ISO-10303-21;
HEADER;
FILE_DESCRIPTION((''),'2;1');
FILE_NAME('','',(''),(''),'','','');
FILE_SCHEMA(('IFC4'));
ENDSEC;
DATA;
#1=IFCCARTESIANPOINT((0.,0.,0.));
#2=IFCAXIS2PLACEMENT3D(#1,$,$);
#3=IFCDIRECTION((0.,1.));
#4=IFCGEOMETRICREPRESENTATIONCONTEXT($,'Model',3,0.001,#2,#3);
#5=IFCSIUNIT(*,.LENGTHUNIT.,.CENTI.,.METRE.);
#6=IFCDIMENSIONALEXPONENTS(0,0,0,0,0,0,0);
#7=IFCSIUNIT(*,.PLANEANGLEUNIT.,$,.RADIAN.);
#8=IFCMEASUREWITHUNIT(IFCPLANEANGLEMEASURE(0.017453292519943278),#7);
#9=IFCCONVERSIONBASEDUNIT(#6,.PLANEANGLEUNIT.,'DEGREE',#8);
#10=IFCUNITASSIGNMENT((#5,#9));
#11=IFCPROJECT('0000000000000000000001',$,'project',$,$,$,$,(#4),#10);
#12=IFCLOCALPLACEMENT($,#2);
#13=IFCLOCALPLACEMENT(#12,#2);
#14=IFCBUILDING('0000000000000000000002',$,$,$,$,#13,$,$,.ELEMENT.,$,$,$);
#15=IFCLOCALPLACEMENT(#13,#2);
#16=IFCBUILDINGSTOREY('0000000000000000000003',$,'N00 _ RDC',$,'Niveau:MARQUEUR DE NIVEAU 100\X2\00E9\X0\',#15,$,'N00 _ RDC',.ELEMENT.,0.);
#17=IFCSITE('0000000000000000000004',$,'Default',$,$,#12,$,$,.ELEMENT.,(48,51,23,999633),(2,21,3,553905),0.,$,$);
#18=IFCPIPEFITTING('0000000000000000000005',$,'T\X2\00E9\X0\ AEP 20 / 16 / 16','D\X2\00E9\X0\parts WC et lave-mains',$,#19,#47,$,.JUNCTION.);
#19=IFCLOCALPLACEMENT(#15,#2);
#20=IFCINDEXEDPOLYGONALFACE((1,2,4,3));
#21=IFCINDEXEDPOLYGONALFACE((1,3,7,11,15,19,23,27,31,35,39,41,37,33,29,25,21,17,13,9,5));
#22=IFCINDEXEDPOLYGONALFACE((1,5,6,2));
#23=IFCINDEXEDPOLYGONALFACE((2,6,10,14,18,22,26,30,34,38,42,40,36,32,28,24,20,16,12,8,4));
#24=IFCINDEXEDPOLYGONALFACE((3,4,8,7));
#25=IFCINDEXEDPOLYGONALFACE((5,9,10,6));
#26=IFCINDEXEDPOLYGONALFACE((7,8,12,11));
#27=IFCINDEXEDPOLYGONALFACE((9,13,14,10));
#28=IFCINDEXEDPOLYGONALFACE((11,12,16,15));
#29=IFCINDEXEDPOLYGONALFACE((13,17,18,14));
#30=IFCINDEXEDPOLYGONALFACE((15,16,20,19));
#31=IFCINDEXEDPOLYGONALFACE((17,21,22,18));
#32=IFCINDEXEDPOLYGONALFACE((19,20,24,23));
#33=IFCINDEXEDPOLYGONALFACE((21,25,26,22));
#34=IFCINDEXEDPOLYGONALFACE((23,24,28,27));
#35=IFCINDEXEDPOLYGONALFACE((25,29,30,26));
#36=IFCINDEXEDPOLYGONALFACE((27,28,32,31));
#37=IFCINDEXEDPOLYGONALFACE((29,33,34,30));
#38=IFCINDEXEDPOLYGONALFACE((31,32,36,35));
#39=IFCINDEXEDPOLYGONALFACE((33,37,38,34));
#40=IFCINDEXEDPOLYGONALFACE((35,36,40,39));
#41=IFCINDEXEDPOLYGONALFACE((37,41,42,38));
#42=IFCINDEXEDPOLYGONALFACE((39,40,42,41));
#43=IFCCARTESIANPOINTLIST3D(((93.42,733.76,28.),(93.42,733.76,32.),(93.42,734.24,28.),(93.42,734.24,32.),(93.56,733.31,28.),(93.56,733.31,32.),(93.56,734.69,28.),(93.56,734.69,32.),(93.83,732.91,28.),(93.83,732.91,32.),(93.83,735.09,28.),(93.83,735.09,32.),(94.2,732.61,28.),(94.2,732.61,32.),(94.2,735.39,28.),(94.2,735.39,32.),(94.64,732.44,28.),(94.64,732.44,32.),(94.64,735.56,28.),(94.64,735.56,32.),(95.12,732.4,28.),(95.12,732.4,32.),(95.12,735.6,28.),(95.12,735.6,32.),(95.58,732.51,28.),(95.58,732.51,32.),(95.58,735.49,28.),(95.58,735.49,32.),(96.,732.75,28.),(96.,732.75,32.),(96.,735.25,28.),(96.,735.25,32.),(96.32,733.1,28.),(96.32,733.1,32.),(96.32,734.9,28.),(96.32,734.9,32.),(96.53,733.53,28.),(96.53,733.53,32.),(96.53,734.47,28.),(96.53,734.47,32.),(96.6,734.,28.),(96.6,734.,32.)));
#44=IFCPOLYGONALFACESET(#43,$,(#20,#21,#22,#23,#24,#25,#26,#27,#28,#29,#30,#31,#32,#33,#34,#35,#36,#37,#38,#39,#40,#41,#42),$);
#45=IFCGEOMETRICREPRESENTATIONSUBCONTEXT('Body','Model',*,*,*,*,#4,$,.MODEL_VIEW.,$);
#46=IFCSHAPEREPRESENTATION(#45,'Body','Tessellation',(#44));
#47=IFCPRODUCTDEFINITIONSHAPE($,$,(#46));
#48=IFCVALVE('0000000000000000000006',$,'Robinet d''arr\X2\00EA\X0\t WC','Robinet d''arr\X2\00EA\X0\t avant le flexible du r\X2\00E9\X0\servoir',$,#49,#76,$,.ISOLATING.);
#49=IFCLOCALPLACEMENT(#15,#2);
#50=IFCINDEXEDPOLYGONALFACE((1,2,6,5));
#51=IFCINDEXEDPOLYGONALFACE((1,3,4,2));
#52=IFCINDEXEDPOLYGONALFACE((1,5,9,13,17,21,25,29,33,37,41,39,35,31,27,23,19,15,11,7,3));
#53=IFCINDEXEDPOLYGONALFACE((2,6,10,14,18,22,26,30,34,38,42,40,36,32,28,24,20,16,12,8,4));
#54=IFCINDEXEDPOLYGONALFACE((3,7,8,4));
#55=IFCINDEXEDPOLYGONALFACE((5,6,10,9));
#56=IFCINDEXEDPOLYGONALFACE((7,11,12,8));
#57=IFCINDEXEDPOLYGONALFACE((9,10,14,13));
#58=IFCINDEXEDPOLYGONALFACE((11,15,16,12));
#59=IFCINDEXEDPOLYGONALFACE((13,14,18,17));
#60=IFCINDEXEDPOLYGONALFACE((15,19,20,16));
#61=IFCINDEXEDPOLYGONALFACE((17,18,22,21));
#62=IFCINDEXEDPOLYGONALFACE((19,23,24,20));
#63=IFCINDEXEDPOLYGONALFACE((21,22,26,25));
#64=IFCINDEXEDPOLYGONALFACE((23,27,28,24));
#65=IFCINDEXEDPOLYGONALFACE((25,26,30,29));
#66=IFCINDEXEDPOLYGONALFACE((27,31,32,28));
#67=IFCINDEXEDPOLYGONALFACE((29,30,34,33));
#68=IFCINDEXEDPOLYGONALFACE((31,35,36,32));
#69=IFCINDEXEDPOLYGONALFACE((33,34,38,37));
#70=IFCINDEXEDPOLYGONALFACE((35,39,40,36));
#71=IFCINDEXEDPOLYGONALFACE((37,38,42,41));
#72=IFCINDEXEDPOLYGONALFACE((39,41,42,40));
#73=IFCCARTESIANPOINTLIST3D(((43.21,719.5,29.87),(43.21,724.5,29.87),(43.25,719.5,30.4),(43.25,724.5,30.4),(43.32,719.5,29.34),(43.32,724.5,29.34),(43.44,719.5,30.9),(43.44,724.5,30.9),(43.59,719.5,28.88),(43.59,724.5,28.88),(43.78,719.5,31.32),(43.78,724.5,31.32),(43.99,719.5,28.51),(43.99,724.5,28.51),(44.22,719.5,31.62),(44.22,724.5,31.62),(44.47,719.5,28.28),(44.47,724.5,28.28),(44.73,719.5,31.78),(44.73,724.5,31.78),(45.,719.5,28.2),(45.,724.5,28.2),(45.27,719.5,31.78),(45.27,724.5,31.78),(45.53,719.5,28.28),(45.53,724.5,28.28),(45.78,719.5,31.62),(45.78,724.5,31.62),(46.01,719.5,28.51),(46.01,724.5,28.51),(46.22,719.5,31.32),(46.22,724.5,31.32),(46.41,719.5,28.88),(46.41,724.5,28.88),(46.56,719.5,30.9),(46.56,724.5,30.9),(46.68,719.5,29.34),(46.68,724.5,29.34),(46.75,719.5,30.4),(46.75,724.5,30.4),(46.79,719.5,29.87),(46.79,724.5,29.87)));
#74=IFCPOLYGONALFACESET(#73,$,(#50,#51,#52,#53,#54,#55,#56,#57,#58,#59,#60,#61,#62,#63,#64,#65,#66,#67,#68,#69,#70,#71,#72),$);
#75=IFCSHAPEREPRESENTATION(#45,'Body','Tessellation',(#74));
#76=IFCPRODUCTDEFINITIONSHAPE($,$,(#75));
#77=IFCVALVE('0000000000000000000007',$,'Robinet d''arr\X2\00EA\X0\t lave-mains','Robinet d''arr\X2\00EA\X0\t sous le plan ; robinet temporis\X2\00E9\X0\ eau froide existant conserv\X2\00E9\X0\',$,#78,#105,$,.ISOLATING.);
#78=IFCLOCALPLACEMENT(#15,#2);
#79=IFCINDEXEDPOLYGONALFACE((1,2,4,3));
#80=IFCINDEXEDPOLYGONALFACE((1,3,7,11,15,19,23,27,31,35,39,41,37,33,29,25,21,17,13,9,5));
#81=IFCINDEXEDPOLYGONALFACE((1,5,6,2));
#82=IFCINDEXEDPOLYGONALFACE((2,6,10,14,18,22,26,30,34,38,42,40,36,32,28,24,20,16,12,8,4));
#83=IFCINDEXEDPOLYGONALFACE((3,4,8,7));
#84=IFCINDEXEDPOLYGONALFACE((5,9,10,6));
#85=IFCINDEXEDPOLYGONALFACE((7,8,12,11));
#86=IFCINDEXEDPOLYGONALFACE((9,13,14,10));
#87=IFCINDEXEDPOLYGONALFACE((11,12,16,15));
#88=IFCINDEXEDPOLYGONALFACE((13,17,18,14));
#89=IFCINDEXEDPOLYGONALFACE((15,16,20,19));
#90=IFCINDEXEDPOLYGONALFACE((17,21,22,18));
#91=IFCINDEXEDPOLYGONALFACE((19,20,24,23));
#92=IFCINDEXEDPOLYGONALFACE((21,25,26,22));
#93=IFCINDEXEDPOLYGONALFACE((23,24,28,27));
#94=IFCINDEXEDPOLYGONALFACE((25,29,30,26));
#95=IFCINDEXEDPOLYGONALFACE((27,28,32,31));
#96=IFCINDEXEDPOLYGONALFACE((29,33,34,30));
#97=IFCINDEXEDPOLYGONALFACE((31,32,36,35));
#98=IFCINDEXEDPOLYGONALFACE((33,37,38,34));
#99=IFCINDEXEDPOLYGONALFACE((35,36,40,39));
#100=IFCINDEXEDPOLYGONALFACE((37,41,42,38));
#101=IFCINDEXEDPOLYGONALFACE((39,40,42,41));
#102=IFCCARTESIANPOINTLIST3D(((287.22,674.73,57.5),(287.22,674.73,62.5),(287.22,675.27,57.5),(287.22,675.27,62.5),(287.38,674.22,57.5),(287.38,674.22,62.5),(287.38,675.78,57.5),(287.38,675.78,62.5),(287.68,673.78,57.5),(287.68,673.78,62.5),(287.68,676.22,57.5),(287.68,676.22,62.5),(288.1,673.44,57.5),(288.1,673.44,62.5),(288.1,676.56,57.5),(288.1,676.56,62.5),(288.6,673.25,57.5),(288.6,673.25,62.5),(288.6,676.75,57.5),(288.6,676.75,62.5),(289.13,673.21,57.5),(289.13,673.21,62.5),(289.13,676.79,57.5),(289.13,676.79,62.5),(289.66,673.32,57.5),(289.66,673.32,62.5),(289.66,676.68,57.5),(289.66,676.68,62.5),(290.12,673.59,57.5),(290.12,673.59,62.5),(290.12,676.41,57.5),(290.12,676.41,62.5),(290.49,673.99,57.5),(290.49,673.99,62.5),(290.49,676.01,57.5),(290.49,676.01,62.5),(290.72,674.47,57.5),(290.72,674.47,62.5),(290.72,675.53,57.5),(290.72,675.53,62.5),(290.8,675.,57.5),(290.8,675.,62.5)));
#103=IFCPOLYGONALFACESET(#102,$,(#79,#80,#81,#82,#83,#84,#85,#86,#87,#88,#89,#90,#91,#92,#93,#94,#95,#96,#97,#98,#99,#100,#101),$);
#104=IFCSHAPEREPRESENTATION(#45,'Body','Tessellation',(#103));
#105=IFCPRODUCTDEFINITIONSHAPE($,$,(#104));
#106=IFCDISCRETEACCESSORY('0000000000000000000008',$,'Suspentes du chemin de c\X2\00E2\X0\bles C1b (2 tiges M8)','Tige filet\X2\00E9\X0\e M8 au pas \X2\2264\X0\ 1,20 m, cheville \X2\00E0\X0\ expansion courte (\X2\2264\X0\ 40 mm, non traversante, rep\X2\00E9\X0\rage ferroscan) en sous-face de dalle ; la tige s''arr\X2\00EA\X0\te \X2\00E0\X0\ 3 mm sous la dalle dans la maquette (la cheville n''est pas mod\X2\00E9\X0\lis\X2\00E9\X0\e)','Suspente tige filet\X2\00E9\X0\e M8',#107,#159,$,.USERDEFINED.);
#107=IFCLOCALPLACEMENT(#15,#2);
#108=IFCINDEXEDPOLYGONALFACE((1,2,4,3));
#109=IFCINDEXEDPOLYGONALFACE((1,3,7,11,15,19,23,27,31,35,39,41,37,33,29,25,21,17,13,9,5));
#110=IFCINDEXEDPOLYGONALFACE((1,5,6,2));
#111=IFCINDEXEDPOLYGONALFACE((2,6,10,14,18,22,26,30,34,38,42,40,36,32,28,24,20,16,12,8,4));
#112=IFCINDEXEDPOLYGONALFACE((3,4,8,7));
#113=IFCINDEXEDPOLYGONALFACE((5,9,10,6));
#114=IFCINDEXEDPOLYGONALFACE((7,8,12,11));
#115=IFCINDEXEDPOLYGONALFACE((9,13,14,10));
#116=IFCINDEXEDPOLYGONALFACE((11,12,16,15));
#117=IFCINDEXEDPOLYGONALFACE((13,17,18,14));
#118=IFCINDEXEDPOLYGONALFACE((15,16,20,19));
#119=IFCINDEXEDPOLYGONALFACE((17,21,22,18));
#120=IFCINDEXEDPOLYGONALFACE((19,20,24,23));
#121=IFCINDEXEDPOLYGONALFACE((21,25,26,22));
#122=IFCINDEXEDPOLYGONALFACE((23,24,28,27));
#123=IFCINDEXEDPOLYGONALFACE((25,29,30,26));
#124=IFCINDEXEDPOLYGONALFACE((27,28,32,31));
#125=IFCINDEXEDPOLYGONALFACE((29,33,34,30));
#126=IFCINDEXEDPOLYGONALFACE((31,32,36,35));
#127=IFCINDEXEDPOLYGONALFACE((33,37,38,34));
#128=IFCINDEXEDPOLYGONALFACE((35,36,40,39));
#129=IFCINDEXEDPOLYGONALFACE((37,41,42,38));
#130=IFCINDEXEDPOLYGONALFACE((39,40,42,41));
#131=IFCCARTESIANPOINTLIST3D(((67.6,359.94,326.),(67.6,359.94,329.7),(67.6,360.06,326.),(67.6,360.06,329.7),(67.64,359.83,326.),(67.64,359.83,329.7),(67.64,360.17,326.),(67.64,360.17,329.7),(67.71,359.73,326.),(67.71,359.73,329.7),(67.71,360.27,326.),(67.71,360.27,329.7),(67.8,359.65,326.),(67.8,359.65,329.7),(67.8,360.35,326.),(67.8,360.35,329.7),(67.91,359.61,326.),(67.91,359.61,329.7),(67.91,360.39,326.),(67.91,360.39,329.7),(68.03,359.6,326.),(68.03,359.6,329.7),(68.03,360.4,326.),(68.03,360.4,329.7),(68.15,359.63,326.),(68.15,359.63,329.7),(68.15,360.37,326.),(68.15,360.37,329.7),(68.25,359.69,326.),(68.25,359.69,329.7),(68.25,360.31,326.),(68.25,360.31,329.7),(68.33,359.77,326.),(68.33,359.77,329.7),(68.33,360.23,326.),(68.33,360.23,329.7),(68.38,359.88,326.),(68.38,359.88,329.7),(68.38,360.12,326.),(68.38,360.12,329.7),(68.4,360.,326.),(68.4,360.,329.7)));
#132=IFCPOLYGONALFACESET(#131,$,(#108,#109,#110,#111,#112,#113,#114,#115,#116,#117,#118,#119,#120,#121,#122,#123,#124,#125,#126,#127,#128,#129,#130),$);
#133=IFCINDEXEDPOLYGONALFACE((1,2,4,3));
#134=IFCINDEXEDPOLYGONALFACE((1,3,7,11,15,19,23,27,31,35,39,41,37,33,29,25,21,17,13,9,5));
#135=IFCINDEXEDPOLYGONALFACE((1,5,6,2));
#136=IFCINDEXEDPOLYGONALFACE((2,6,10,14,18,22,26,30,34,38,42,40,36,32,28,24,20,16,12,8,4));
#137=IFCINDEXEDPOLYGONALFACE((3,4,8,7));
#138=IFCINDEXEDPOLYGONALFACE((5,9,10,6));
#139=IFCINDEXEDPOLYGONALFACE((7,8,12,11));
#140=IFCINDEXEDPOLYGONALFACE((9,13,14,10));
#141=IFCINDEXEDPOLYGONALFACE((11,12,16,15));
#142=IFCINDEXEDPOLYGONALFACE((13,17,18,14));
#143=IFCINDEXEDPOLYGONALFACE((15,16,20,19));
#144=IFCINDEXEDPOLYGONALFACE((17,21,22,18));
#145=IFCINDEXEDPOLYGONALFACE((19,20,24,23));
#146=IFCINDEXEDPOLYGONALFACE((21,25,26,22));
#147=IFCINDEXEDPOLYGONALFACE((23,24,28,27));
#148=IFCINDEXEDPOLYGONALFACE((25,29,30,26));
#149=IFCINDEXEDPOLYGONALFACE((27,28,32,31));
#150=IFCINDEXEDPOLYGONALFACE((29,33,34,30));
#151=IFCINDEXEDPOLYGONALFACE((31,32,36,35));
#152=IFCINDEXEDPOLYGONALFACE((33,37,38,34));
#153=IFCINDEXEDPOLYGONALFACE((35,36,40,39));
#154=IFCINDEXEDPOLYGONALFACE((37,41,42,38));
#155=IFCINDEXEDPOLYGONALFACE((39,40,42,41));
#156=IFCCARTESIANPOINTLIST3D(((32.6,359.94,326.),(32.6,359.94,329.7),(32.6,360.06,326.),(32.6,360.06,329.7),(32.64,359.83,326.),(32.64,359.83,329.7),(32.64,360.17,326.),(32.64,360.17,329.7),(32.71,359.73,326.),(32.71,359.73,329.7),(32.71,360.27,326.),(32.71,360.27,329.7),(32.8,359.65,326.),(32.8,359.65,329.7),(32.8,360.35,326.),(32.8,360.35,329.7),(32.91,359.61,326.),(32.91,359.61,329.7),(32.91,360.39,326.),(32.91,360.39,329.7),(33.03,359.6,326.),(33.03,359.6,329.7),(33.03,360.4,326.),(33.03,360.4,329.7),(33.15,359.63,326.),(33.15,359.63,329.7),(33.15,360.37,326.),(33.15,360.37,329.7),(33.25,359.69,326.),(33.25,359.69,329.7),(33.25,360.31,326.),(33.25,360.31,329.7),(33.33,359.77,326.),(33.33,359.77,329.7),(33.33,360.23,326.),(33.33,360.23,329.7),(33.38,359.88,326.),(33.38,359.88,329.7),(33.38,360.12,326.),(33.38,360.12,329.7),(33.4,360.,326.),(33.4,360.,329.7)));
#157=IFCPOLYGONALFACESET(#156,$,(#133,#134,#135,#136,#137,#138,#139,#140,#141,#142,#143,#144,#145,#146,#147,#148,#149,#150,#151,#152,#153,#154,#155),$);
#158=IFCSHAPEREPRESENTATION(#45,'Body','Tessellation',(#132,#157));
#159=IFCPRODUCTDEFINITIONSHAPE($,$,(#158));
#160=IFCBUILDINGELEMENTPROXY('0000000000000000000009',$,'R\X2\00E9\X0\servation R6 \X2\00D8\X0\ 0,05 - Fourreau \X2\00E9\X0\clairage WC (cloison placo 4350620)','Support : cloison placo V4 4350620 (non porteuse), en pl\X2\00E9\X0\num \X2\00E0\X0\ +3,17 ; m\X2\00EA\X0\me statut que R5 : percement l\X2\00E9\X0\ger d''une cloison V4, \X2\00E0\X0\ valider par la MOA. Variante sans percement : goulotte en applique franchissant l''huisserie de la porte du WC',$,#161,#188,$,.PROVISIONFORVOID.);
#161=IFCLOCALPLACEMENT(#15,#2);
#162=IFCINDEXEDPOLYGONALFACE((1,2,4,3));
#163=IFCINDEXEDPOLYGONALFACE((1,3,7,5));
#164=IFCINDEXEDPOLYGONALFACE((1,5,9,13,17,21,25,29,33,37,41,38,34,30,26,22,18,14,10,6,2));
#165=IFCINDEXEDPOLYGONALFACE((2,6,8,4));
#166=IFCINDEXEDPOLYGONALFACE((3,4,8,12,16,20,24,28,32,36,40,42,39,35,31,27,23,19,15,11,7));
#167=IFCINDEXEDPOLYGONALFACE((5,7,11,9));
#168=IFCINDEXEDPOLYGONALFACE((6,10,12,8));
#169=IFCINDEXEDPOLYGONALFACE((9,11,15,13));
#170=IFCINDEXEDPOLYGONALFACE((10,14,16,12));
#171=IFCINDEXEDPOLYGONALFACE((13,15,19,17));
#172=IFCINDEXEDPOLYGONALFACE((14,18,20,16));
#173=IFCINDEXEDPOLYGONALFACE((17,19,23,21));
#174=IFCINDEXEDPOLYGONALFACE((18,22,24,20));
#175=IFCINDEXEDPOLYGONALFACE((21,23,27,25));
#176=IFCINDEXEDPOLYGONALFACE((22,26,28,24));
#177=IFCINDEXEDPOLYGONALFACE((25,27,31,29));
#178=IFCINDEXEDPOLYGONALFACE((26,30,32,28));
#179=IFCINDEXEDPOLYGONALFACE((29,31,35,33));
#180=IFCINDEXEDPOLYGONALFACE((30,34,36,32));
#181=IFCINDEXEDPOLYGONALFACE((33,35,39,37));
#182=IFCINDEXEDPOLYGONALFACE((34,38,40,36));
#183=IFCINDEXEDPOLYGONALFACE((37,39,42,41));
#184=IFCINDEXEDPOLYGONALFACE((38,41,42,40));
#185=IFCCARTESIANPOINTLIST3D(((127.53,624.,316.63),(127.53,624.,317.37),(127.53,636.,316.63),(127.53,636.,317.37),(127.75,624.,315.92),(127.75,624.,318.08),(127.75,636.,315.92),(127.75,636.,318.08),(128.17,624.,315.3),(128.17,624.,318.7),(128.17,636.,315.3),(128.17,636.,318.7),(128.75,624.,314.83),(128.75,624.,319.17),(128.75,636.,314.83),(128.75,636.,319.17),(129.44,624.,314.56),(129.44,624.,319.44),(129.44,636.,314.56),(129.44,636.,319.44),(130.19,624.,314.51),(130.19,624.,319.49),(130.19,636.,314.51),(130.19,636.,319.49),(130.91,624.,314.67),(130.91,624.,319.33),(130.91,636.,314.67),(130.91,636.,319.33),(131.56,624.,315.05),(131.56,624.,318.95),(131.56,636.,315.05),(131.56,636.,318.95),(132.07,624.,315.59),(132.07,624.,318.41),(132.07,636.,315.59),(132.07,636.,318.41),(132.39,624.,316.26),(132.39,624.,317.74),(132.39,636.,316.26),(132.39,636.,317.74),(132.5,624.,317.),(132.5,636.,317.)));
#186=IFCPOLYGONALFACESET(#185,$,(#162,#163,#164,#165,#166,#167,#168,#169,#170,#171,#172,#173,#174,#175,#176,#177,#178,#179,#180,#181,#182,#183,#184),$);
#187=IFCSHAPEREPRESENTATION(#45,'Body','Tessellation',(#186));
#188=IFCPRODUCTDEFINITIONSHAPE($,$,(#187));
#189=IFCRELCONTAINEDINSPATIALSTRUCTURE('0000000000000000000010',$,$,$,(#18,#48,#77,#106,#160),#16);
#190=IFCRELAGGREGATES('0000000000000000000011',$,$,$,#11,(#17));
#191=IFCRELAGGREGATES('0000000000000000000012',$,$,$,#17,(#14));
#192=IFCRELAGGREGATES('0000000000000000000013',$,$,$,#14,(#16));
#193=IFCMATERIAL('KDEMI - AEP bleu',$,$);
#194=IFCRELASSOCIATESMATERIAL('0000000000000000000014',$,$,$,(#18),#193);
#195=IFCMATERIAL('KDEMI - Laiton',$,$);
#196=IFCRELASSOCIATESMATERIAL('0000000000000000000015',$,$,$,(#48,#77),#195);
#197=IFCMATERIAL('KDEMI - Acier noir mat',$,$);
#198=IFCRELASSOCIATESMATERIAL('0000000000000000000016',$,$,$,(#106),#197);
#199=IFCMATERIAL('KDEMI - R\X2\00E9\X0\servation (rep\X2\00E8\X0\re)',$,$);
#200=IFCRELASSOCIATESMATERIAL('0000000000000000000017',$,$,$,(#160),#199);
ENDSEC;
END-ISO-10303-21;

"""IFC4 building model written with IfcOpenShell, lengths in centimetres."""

from ifc_helpers import new_model, entity, si_unit, converted_unit, direction, frame, frame_2d, origin, origin_with_axes, origin_2d, place, context, subcontext, project, spatial, circle, extrude, material, element, save


model = new_model("IFC4")

# Units and contexts
model_context = context("Model", 3, precision=0.001, world=origin(), true_north=direction((0.0, 1.0)))
body_context = subcontext(model_context, "Body", "Model", "MODEL_VIEW")
ifc_project = project(units=[si_unit("LENGTHUNIT", "METRE", prefix="CENTI"), converted_unit("PLANEANGLEUNIT", "DEGREE", entity("IfcPlaneAngleMeasure", 0.017453292519943278), si_unit("PLANEANGLEUNIT", "RADIAN"), dimensions=[0, 0, 0, 0, 0, 0, 0])], contexts=[model_context])

# Site, building, storey
site_placement = place(None, origin())
site = spatial("IfcSite", under=ifc_project, at=site_placement, Name="Default", CompositionType="ELEMENT", RefLatitude=(48, 51, 23, 999633), RefLongitude=(2, 21, 3, 553905), RefElevation=0.0)
building_placement = place(site_placement, origin())
building = spatial("IfcBuilding", under=site, at=building_placement, CompositionType="ELEMENT")
storey_placement = place(building_placement, origin())
storey = spatial("IfcBuildingStorey", under=building, at=storey_placement, Name="N00 _ RDC", ObjectType="Niveau:MARQUEUR DE NIVEAU 100é", LongName="N00 _ RDC", CompositionType="ELEMENT", Elevation=0.0)

# Shared definitions
ifc_material_1 = material(Name="KDEMI - AEP bleu")

# Shared definitions
ifc_material_2 = material(Name="KDEMI - Laiton")

# Pipe fitting
pipe_fitting_1_placement = place(storey_placement, origin_with_axes())
element("IfcPipeFitting", 1, at=pipe_fitting_1_placement, inside=storey, material=ifc_material_1, Name="Té AEP 20 / 16 / 16", Description="Départs WC et lave-mains", PredefinedType="JUNCTION", context=body_context, shape_type="SweptSolid", body=[
    extrude(circle(Radius=1.6, at=frame_2d((95.0, 734.0))), frame((0.0, 0.0, 28.0)), (0.0, 0.0, 1.0), 4.0),
])

# Valves
valve_1_placement = place(storey_placement, origin_with_axes())
element("IfcValve", 2, at=valve_1_placement, inside=storey, material=ifc_material_2, Name="Robinet d'arrêt WC", Description="Robinet d'arrêt avant le flexible du réservoir", PredefinedType="ISOLATING", context=body_context, shape_type="AdvancedSweptSolid", body=[
    entity("IfcSweptDiskSolid", entity("IfcPolyline", [entity("IfcCartesianPoint", [45.0, 724.5, 30.0]), entity("IfcCartesianPoint", [45.0, 719.5, 30.0])]), 1.8),
])
valve_2_placement = place(storey_placement, origin_with_axes())
element("IfcValve", 3, at=valve_2_placement, inside=storey, material=ifc_material_2, Name="Robinet d'arrêt lave-mains", Description="Robinet d'arrêt sous le plan ; robinet temporisé eau froide existant conservé", PredefinedType="ISOLATING", context=body_context, shape_type="SweptSolid", body=[
    extrude(circle(Radius=1.8, at=frame_2d((289.0, 675.0))), frame((0.0, 0.0, 57.5)), (0.0, 0.0, 1.0), 5.0),
])

# Discrete accessory
ifc_material_3 = material(Name="KDEMI - Acier noir mat")
discrete_accessory_1_placement = place(storey_placement, origin_with_axes())
element("IfcDiscreteAccessory", 4, at=discrete_accessory_1_placement, inside=storey, material=ifc_material_3, Name="Suspentes du chemin de câbles C1b (2 tiges M8)", Description="Tige filetée M8 au pas ≤ 1,20 m, cheville à expansion courte (≤ 40 mm, non traversante, repérage ferroscan) en sous-face de dalle ; la tige s'arrête à 3 mm sous la dalle dans la maquette (la cheville n'est pas modélisée)", ObjectType="Suspente tige filetée M8", PredefinedType="USERDEFINED", context=body_context, shape_type="SweptSolid", body=[
    extrude(circle(Radius=0.4, at=frame_2d((68.0, 360.0))), frame((0.0, 0.0, 326.0)), (0.0, 0.0, 1.0), 3.7),
    extrude(circle(Radius=0.4, at=frame_2d((33.0, 360.0))), frame((0.0, 0.0, 326.0)), (0.0, 0.0, 1.0), 3.7),
])

# Building element proxy
ifc_material_4 = material(Name="KDEMI - Réservation (repère)")
proxy_1_placement = place(storey_placement, origin_with_axes())
element("IfcBuildingElementProxy", 5, at=proxy_1_placement, inside=storey, material=ifc_material_4, Name="Réservation R6 Ø 0,05 - Fourreau éclairage WC (cloison placo 4350620)", Description="Support : cloison placo V4 4350620 (non porteuse), en plénum à +3,17 ; même statut que R5 : percement léger d'une cloison V4, à valider par la MOA. Variante sans percement : goulotte en applique franchissant l'huisserie de la porte du WC", PredefinedType="PROVISIONFORVOID", context=body_context, shape_type="SweptSolid", body=[
    extrude(circle(Radius=2.5, at=origin_2d()), frame((130.0, 624.0, 317.0), z_axis=(0.0, 1.0, 0.0), x_axis=(1.0, 0.0, 0.0)), (0.0, 0.0, 1.0), 12.0),
])

save(model, "model.ifc")
